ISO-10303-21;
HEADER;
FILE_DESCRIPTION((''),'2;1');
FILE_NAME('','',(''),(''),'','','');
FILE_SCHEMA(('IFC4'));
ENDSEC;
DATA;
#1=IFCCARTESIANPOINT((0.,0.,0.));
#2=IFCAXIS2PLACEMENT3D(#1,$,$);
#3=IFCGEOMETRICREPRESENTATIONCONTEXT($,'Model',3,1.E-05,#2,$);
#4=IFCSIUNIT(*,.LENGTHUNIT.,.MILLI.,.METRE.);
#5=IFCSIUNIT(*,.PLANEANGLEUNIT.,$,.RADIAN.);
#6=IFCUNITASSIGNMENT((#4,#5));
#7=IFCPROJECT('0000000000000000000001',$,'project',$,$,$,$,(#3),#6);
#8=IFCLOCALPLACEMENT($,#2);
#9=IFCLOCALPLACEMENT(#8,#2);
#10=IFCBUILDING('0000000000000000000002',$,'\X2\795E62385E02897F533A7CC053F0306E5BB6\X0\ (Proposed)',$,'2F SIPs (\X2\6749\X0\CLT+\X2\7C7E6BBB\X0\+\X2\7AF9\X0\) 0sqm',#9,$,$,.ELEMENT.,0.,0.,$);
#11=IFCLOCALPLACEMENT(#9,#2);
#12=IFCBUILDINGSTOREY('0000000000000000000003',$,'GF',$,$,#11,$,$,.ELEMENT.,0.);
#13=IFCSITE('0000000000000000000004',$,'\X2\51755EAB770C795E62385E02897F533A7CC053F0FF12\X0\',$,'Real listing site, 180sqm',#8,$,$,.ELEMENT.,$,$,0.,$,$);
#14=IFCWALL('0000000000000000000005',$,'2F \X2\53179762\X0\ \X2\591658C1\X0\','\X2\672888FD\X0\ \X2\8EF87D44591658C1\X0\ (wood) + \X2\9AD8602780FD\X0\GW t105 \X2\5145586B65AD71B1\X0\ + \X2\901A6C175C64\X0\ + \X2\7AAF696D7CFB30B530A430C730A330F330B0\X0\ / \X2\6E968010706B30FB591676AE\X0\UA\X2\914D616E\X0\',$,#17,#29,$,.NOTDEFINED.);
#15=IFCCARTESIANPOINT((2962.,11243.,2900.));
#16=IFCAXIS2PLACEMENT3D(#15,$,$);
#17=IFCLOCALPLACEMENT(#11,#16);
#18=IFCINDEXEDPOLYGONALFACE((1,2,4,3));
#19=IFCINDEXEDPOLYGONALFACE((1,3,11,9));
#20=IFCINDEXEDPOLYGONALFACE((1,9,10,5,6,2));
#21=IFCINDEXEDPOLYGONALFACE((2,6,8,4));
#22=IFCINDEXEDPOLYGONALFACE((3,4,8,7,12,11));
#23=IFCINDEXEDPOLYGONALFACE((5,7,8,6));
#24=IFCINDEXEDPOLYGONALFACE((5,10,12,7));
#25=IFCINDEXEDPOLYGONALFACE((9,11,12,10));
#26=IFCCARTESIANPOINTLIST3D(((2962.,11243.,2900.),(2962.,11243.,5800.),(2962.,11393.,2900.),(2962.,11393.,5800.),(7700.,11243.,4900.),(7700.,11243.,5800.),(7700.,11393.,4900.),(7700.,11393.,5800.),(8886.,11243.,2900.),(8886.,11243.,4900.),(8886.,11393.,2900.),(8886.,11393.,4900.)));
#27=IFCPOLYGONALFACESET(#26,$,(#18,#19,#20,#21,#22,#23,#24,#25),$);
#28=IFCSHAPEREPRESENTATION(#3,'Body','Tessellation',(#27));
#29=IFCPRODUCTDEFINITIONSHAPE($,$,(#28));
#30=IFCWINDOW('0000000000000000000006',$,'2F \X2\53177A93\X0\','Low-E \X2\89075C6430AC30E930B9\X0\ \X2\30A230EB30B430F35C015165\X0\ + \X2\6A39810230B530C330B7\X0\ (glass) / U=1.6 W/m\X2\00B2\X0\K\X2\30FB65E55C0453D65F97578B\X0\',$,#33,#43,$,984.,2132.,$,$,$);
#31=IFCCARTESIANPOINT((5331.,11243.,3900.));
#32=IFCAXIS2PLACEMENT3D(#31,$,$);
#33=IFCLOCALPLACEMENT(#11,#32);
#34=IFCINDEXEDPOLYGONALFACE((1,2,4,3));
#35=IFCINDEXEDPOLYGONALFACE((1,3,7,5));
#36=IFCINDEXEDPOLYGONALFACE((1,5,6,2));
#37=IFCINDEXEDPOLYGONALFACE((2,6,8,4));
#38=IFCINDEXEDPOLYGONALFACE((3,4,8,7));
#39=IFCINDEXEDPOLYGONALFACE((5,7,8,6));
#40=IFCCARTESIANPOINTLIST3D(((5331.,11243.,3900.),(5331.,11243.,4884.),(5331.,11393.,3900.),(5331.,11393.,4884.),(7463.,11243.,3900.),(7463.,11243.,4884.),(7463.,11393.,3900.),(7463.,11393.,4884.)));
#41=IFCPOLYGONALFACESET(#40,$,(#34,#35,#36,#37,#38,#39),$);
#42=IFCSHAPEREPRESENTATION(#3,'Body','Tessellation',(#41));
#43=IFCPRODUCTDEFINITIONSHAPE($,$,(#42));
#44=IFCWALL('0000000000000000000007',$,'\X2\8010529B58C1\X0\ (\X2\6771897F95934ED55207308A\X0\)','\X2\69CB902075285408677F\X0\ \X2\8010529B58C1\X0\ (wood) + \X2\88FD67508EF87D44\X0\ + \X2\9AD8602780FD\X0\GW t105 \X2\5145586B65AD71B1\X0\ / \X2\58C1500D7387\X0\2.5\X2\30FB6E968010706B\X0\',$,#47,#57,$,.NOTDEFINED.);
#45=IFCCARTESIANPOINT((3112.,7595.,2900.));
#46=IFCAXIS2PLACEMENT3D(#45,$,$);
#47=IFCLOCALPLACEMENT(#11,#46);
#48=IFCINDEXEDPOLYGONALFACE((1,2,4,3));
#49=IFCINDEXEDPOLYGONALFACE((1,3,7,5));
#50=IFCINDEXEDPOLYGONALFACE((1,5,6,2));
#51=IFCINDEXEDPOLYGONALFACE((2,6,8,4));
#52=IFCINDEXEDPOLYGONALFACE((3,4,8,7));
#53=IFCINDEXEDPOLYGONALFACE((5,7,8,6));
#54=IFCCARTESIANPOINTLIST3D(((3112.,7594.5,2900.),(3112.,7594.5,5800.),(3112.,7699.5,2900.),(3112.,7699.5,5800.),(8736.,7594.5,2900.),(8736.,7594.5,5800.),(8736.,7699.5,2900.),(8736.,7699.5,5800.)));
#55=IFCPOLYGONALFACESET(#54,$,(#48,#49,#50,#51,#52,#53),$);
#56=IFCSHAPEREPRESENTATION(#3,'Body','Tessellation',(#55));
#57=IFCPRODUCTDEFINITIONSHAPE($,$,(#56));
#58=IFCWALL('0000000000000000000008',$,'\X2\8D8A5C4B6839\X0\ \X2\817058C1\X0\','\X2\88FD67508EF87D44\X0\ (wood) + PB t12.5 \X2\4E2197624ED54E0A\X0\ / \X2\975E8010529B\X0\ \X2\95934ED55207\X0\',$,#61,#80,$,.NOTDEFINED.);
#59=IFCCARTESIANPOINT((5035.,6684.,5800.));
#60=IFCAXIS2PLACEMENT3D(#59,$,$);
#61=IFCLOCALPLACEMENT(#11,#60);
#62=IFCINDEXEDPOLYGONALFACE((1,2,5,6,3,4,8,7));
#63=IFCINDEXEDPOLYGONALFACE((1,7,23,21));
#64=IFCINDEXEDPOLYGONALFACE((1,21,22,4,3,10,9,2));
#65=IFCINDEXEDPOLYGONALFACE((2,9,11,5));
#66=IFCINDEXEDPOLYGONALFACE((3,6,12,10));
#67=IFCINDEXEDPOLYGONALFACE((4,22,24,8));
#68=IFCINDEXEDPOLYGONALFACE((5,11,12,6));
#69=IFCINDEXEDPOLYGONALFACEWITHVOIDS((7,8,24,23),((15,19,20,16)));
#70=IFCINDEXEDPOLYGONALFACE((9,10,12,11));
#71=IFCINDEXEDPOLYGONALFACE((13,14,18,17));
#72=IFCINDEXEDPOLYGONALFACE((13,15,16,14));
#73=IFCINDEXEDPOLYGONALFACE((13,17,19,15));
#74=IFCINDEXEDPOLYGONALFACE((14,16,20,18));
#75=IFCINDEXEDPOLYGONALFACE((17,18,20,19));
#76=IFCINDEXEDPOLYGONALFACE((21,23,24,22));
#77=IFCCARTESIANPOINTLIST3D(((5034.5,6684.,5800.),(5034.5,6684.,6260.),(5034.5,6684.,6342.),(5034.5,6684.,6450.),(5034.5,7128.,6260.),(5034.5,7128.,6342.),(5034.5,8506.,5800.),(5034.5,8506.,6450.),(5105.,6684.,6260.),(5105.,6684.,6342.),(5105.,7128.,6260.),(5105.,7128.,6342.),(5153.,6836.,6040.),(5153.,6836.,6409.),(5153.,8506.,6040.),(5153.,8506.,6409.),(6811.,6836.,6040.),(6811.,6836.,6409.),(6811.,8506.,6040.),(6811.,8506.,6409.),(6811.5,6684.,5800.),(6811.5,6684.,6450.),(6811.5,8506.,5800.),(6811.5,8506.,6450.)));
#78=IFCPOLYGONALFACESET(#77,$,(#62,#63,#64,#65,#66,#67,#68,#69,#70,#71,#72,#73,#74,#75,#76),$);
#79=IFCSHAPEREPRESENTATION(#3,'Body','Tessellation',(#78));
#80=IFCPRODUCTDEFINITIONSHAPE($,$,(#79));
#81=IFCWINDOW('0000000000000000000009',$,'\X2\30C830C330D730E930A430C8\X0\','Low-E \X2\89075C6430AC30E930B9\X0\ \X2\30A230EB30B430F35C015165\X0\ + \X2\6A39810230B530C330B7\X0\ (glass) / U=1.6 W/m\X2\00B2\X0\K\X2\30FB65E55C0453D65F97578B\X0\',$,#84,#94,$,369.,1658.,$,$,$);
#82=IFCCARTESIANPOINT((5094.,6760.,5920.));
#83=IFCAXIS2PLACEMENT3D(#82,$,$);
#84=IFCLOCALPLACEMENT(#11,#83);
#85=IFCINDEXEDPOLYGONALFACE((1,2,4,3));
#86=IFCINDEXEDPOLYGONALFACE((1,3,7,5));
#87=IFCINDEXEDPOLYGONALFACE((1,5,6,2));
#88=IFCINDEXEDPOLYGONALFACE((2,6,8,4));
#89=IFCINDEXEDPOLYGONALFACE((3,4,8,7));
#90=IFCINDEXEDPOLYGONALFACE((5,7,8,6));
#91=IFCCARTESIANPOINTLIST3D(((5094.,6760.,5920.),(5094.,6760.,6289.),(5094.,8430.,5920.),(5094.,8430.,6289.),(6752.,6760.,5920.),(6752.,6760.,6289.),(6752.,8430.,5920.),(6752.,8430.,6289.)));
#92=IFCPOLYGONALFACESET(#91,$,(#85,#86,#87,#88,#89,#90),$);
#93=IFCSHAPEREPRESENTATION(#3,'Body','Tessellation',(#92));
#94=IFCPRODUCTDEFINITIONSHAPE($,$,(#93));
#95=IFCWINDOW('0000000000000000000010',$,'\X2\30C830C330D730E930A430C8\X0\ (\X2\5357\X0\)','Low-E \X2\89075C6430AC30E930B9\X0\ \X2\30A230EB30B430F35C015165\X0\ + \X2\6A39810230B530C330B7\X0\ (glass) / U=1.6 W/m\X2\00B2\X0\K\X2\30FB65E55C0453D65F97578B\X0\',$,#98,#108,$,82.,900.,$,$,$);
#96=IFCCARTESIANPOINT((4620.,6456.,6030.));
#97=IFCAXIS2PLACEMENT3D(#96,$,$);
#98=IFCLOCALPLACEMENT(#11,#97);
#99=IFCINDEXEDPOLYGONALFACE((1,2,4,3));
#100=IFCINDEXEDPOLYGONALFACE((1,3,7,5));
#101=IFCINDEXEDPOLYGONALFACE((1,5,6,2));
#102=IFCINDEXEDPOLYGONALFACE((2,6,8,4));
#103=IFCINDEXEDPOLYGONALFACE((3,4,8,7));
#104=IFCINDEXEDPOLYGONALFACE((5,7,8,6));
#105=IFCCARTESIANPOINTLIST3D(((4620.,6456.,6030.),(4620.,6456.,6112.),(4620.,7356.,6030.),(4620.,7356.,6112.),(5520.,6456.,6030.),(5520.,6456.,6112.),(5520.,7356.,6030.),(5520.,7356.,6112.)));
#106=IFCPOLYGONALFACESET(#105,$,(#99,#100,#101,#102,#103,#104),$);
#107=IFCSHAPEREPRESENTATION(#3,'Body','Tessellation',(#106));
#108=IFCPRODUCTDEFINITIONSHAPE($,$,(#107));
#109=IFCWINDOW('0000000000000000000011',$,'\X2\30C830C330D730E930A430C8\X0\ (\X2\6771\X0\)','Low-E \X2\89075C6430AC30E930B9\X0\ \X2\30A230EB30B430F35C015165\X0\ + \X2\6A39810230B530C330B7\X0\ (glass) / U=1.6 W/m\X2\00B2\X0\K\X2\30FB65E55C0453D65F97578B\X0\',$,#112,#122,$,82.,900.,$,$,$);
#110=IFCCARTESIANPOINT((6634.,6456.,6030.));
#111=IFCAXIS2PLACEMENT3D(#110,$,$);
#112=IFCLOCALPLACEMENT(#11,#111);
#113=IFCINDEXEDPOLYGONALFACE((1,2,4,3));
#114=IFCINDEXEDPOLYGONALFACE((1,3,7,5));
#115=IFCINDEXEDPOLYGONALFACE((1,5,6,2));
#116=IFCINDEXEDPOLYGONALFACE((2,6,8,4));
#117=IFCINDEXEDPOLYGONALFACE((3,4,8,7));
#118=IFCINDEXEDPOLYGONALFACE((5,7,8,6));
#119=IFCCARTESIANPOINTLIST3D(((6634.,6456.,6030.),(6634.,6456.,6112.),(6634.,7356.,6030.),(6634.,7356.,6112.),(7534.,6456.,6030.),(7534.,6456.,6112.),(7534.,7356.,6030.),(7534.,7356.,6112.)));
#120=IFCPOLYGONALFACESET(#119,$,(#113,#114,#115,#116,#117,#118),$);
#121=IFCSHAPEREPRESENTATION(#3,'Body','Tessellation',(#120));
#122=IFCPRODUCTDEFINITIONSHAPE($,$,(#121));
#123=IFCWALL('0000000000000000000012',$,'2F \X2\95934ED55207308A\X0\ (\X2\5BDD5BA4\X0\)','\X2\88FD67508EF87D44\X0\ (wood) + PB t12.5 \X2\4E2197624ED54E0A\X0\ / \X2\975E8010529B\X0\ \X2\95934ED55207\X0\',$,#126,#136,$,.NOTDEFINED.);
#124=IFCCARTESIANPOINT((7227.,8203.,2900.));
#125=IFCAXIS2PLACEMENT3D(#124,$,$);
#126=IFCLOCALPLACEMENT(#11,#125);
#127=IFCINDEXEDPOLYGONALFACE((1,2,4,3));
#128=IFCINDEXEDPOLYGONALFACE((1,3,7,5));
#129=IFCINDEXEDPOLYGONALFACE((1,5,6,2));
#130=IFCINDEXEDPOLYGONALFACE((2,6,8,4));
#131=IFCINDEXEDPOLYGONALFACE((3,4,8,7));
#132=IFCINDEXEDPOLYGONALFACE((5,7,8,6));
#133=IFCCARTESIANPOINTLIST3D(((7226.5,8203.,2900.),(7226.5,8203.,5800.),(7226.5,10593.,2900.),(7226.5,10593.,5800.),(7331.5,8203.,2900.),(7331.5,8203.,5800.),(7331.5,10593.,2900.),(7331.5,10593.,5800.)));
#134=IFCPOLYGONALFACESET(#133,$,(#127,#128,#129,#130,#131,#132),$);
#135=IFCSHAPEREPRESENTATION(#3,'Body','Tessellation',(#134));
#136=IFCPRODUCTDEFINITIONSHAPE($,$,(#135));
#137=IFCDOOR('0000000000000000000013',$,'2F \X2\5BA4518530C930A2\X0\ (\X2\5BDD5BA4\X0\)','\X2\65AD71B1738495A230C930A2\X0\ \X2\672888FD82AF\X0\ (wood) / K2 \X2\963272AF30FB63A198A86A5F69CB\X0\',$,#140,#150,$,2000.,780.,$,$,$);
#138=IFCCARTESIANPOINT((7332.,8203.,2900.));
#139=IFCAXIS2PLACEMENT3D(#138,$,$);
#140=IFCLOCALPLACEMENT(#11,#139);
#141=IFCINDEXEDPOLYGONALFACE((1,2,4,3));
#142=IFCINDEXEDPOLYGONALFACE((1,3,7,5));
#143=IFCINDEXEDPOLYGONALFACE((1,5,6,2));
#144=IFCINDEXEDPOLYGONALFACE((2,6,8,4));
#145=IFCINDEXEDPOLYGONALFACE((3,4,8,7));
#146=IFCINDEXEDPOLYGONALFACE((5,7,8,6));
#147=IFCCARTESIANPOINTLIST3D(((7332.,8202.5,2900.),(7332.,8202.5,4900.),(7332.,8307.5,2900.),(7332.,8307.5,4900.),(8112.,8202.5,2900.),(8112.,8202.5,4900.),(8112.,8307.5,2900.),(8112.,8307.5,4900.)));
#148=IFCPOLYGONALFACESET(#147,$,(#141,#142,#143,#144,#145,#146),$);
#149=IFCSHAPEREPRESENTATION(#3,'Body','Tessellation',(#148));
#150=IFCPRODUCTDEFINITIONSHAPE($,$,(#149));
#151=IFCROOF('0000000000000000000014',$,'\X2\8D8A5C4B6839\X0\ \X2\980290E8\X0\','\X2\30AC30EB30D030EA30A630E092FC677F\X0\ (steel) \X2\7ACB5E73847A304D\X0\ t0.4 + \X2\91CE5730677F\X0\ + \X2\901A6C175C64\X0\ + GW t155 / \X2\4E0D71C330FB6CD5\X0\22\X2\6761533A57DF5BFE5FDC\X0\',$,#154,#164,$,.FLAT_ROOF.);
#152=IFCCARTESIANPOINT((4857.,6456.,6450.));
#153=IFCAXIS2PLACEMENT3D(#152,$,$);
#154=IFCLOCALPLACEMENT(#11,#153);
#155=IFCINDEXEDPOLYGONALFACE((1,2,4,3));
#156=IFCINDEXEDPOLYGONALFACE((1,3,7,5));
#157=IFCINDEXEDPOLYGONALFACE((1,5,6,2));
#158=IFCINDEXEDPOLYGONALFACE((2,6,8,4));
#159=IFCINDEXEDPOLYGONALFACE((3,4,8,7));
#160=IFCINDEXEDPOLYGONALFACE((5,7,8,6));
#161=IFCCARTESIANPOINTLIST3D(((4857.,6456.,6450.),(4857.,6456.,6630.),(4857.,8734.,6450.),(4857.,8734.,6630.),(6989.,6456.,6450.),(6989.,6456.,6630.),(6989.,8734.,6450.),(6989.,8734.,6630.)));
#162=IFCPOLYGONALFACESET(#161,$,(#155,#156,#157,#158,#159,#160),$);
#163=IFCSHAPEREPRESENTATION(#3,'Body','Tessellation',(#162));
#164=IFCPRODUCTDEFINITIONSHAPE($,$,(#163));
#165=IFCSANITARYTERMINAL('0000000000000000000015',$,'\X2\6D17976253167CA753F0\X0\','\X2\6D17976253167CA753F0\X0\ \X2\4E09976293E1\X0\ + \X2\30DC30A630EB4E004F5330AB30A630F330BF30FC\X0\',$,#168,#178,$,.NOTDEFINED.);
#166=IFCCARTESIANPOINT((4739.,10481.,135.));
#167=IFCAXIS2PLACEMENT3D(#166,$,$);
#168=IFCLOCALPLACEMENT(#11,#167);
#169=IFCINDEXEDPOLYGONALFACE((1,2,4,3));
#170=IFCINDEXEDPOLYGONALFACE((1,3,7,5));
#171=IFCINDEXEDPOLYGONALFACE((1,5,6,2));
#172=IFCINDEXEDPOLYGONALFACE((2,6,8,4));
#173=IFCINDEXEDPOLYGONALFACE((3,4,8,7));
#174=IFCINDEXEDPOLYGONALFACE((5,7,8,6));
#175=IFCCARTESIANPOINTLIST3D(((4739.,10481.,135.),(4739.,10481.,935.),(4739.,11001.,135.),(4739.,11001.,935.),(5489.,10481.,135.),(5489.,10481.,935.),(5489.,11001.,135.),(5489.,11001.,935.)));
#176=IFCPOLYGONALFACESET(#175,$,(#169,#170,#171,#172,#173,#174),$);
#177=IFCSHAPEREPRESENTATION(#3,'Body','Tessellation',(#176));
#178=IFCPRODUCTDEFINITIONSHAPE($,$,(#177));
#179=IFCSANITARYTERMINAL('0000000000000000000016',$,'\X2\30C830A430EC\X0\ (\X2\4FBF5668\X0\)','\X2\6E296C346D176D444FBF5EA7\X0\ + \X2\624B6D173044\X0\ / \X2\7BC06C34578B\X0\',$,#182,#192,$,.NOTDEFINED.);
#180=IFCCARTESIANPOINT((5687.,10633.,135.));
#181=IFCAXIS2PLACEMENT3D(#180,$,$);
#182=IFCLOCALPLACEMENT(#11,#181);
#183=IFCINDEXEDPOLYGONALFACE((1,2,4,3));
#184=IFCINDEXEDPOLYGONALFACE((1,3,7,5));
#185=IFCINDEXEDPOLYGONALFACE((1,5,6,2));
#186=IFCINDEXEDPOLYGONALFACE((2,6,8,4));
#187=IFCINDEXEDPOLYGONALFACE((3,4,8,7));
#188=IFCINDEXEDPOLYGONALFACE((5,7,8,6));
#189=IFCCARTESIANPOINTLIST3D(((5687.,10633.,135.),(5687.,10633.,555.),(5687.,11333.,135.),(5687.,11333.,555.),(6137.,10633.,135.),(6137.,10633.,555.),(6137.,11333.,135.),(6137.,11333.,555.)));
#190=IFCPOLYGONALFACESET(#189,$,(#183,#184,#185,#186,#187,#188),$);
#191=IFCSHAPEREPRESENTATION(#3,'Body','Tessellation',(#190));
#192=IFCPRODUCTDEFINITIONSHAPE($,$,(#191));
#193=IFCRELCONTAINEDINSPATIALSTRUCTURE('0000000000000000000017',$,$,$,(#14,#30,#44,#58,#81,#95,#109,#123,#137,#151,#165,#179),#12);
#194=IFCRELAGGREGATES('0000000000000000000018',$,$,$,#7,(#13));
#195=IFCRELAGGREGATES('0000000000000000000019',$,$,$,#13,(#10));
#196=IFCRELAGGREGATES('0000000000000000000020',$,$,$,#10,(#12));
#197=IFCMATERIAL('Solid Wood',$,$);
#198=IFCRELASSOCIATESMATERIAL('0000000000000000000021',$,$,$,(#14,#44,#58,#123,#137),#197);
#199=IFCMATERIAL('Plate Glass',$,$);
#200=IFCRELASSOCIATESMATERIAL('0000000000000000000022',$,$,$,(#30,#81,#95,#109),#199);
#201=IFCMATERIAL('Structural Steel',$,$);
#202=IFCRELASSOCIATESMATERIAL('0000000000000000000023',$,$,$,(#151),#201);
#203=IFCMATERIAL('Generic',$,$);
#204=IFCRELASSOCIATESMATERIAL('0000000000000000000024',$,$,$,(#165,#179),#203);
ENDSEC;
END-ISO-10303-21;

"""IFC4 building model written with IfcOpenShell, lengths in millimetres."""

from ifc_helpers import new_model, si_unit, frame, frame_2d, origin, place, context, project, spatial, rectangle, extrude, material, element, fill, save


model = new_model("IFC4")

# Units and contexts
model_context = context("Model", 3, precision=1e-05, world=origin())
ifc_project = project(units=[si_unit("LENGTHUNIT", "METRE", prefix="MILLI"), si_unit("PLANEANGLEUNIT", "RADIAN")], contexts=[model_context])

# Site, building, storey
site_placement = place(None, origin())
site = spatial("IfcSite", under=ifc_project, at=site_placement, Name="兵庫県神戸市西区糀台２", ObjectType="Real listing site, 180sqm", CompositionType="ELEMENT", RefElevation=0.0)
building_placement = place(site_placement, origin())
building = spatial("IfcBuilding", under=site, at=building_placement, Name="神戸市西区糀台の家 (Proposed)", ObjectType="2F SIPs (杉CLT+籾殻+竹) 0sqm", CompositionType="ELEMENT", ElevationOfRefHeight=0.0, ElevationOfTerrain=0.0)
storey_placement = place(building_placement, origin())
storey = spatial("IfcBuildingStorey", under=building, at=storey_placement, Name="GF", CompositionType="ELEMENT", Elevation=0.0)

# Wall, opening, window
ifc_material_1 = material(Name="Solid Wood")
wall_1_placement = place(storey_placement, frame((2962.0, 11243.0, 2900.0)))
wall_1 = element("IfcWall", 1, at=wall_1_placement, inside=storey, material=ifc_material_1, Name="2F 北面 外壁", Description="木製 軸組外壁 (wood) + 高性能GW t105 充填断熱 + 通気層 + 窯業系サイディング / 準耐火・外皮UA配慮", PredefinedType="NOTDEFINED", context=model_context, shape_type="SweptSolid", body=[
    extrude(rectangle(XDim=5924.0, YDim=150.0, at=frame_2d((2962.0, 75.0))), frame((2962.0, 11243.0, 2900.0)), (0.0, 0.0, 1.0), 2900.0),
])
opening_1_placement = place(storey_placement, frame((5331.0, 11243.0, 3900.0)))
opening_1 = element("IfcOpeningElement", 2, at=opening_1_placement, cuts=wall_1, PredefinedType="NOTDEFINED", context=model_context, shape_type="SweptSolid", body=[
    extrude(rectangle(XDim=2132.0, YDim=150.0, at=frame_2d((1066.0, 75.0))), frame((5331.0, 11243.0, 3900.0)), (0.0, 0.0, 1.0), 984.0),
])
ifc_material_2 = material(Name="Plate Glass")
window_1_placement = place(storey_placement, frame((5331.0, 11243.0, 3900.0)))
window_1 = element("IfcWindow", 3, at=window_1_placement, inside=storey, material=ifc_material_2, Name="2F 北窓", Description="Low-E 複層ガラス アルゴン封入 + 樹脂サッシ (glass) / U=1.6 W/m²K・日射取得型", OverallHeight=984.0, OverallWidth=2132.0, context=model_context, shape_type="SweptSolid", body=[
    extrude(rectangle(XDim=2132.0, YDim=150.0, at=frame_2d((1066.0, 75.0))), frame((5331.0, 11243.0, 3900.0)), (0.0, 0.0, 1.0), 984.0),
])
fill(opening_1, window_1)

# Wall
wall_2_placement = place(storey_placement, frame((3112.0, 7595.0, 2900.0)))
element("IfcWall", 4, at=wall_2_placement, inside=storey, material=ifc_material_1, Name="耐力壁 (東西間仕切り)", Description="構造用合板 耐力壁 (wood) + 製材軸組 + 高性能GW t105 充填断熱 / 壁倍率2.5・準耐火", PredefinedType="NOTDEFINED", context=model_context, shape_type="SweptSolid", body=[
    extrude(rectangle(XDim=5624.0, YDim=105.0, at=frame_2d((2812.0, 52.0))), frame((3112.0, 7595.0, 2900.0)), (0.0, 0.0, 1.0), 2900.0),
])

# Wall, openings, windows
wall_3_placement = place(storey_placement, frame((5035.0, 6684.0, 5800.0)))
wall_3 = element("IfcWall", 5, at=wall_3_placement, inside=storey, material=ifc_material_1, Name="越屋根 腰壁", Description="製材軸組 (wood) + PB t12.5 両面仕上 / 非耐力 間仕切", PredefinedType="NOTDEFINED", context=model_context, shape_type="SweptSolid", body=[
    extrude(rectangle(XDim=1777.0, YDim=1822.0, at=frame_2d((888.0, 911.0))), frame((5035.0, 6684.0, 5800.0)), (0.0, 0.0, 1.0), 650.0),
])
opening_2_placement = place(storey_placement, frame((5094.0, 6760.0, 5920.0)))
opening_2 = element("IfcOpeningElement", 6, at=opening_2_placement, cuts=wall_3, PredefinedType="NOTDEFINED", context=model_context, shape_type="SweptSolid", body=[
    extrude(rectangle(XDim=1658.0, YDim=1670.0, at=frame_2d((829.0, 835.0))), frame((5094.0, 6760.0, 5920.0)), (0.0, 0.0, 1.0), 369.0),
])
opening_3_placement = place(storey_placement, frame((4620.0, 6456.0, 6030.0)))
opening_3 = element("IfcOpeningElement", 7, at=opening_3_placement, cuts=wall_3, PredefinedType="NOTDEFINED", context=model_context, shape_type="SweptSolid", body=[
    extrude(rectangle(XDim=900.0, YDim=900.0, at=frame_2d((450.0, 450.0))), frame((4620.0, 6456.0, 6030.0)), (0.0, 0.0, 1.0), 82.0),
])
opening_4_placement = place(storey_placement, frame((6634.0, 6456.0, 6030.0)))
opening_4 = element("IfcOpeningElement", 8, at=opening_4_placement, cuts=wall_3, PredefinedType="NOTDEFINED", context=model_context, shape_type="SweptSolid", body=[
    extrude(rectangle(XDim=900.0, YDim=900.0, at=frame_2d((450.0, 450.0))), frame((6634.0, 6456.0, 6030.0)), (0.0, 0.0, 1.0), 82.0),
])
window_2_placement = place(storey_placement, frame((5094.0, 6760.0, 5920.0)))
window_2 = element("IfcWindow", 9, at=window_2_placement, inside=storey, material=ifc_material_2, Name="トップライト", Description="Low-E 複層ガラス アルゴン封入 + 樹脂サッシ (glass) / U=1.6 W/m²K・日射取得型", OverallHeight=369.0, OverallWidth=1658.0, context=model_context, shape_type="SweptSolid", body=[
    extrude(rectangle(XDim=1658.0, YDim=1670.0, at=frame_2d((829.0, 835.0))), frame((5094.0, 6760.0, 5920.0)), (0.0, 0.0, 1.0), 369.0),
])
fill(opening_2, window_2)
window_3_placement = place(storey_placement, frame((4620.0, 6456.0, 6030.0)))
window_3 = element("IfcWindow", 10, at=window_3_placement, inside=storey, material=ifc_material_2, Name="トップライト (南)", Description="Low-E 複層ガラス アルゴン封入 + 樹脂サッシ (glass) / U=1.6 W/m²K・日射取得型", OverallHeight=82.0, OverallWidth=900.0, context=model_context, shape_type="SweptSolid", body=[
    extrude(rectangle(XDim=900.0, YDim=900.0, at=frame_2d((450.0, 450.0))), frame((4620.0, 6456.0, 6030.0)), (0.0, 0.0, 1.0), 82.0),
])
fill(opening_3, window_3)
window_4_placement = place(storey_placement, frame((6634.0, 6456.0, 6030.0)))
window_4 = element("IfcWindow", 11, at=window_4_placement, inside=storey, material=ifc_material_2, Name="トップライト (東)", Description="Low-E 複層ガラス アルゴン封入 + 樹脂サッシ (glass) / U=1.6 W/m²K・日射取得型", OverallHeight=82.0, OverallWidth=900.0, context=model_context, shape_type="SweptSolid", body=[
    extrude(rectangle(XDim=900.0, YDim=900.0, at=frame_2d((450.0, 450.0))), frame((6634.0, 6456.0, 6030.0)), (0.0, 0.0, 1.0), 82.0),
])
fill(opening_4, window_4)

# Wall
wall_4_placement = place(storey_placement, frame((7227.0, 8203.0, 2900.0)))
element("IfcWall", 12, at=wall_4_placement, inside=storey, material=ifc_material_1, Name="2F 間仕切り (寝室)", Description="製材軸組 (wood) + PB t12.5 両面仕上 / 非耐力 間仕切", PredefinedType="NOTDEFINED", context=model_context, shape_type="SweptSolid", body=[
    extrude(rectangle(XDim=105.0, YDim=2390.0, at=frame_2d((52.0, 1195.0))), frame((7227.0, 8203.0, 2900.0)), (0.0, 0.0, 1.0), 2900.0),
])

# Door
door_placement = place(storey_placement, frame((7332.0, 8203.0, 2900.0)))
element("IfcDoor", 13, at=door_placement, inside=storey, material=ifc_material_1, Name="2F 室内ドア (寝室)", Description="断熱玄関ドア 木製芯 (wood) / K2 防犯・採風機構", OverallHeight=2000.0, OverallWidth=780.0, context=model_context, shape_type="SweptSolid", body=[
    extrude(rectangle(XDim=780.0, YDim=105.0, at=frame_2d((390.0, 52.0))), frame((7332.0, 8203.0, 2900.0)), (0.0, 0.0, 1.0), 2000.0),
])

# Roof
ifc_material_3 = material(Name="Structural Steel")
roof_placement = place(storey_placement, frame((4857.0, 6456.0, 6450.0)))
element("IfcRoof", 14, at=roof_placement, inside=storey, material=ifc_material_3, Name="越屋根 頂部", Description="ガルバリウム鋼板 (steel) 立平葺き t0.4 + 野地板 + 通気層 + GW t155 / 不燃・法22条区域対応", PredefinedType="FLAT_ROOF", context=model_context, shape_type="SweptSolid", body=[
    extrude(rectangle(XDim=2132.0, YDim=2278.0, at=frame_2d((1066.0, 1139.0))), frame((4857.0, 6456.0, 6450.0)), (0.0, 0.0, 1.0), 180.0),
])

# Sanitary terminals
ifc_material_4 = material(Name="Generic")
sanitary_terminal_1_placement = place(storey_placement, frame((4739.0, 10481.0, 135.0)))
element("IfcSanitaryTerminal", 15, at=sanitary_terminal_1_placement, inside=storey, material=ifc_material_4, Name="洗面化粧台", Description="洗面化粧台 三面鏡 + ボウル一体カウンター", PredefinedType="NOTDEFINED", context=model_context, shape_type="SweptSolid", body=[
    extrude(rectangle(XDim=750.0, YDim=520.0, at=frame_2d((375.0, 260.0))), frame((4739.0, 10481.0, 135.0)), (0.0, 0.0, 1.0), 800.0),
])
sanitary_terminal_2_placement = place(storey_placement, frame((5687.0, 10633.0, 135.0)))
element("IfcSanitaryTerminal", 16, at=sanitary_terminal_2_placement, inside=storey, material=ifc_material_4, Name="トイレ (便器)", Description="温水洗浄便座 + 手洗い / 節水型", PredefinedType="NOTDEFINED", context=model_context, shape_type="SweptSolid", body=[
    extrude(rectangle(XDim=450.0, YDim=700.0, at=frame_2d((225.0, 350.0))), frame((5687.0, 10633.0, 135.0)), (0.0, 0.0, 1.0), 420.0),
])

save(model, "model.ifc")
